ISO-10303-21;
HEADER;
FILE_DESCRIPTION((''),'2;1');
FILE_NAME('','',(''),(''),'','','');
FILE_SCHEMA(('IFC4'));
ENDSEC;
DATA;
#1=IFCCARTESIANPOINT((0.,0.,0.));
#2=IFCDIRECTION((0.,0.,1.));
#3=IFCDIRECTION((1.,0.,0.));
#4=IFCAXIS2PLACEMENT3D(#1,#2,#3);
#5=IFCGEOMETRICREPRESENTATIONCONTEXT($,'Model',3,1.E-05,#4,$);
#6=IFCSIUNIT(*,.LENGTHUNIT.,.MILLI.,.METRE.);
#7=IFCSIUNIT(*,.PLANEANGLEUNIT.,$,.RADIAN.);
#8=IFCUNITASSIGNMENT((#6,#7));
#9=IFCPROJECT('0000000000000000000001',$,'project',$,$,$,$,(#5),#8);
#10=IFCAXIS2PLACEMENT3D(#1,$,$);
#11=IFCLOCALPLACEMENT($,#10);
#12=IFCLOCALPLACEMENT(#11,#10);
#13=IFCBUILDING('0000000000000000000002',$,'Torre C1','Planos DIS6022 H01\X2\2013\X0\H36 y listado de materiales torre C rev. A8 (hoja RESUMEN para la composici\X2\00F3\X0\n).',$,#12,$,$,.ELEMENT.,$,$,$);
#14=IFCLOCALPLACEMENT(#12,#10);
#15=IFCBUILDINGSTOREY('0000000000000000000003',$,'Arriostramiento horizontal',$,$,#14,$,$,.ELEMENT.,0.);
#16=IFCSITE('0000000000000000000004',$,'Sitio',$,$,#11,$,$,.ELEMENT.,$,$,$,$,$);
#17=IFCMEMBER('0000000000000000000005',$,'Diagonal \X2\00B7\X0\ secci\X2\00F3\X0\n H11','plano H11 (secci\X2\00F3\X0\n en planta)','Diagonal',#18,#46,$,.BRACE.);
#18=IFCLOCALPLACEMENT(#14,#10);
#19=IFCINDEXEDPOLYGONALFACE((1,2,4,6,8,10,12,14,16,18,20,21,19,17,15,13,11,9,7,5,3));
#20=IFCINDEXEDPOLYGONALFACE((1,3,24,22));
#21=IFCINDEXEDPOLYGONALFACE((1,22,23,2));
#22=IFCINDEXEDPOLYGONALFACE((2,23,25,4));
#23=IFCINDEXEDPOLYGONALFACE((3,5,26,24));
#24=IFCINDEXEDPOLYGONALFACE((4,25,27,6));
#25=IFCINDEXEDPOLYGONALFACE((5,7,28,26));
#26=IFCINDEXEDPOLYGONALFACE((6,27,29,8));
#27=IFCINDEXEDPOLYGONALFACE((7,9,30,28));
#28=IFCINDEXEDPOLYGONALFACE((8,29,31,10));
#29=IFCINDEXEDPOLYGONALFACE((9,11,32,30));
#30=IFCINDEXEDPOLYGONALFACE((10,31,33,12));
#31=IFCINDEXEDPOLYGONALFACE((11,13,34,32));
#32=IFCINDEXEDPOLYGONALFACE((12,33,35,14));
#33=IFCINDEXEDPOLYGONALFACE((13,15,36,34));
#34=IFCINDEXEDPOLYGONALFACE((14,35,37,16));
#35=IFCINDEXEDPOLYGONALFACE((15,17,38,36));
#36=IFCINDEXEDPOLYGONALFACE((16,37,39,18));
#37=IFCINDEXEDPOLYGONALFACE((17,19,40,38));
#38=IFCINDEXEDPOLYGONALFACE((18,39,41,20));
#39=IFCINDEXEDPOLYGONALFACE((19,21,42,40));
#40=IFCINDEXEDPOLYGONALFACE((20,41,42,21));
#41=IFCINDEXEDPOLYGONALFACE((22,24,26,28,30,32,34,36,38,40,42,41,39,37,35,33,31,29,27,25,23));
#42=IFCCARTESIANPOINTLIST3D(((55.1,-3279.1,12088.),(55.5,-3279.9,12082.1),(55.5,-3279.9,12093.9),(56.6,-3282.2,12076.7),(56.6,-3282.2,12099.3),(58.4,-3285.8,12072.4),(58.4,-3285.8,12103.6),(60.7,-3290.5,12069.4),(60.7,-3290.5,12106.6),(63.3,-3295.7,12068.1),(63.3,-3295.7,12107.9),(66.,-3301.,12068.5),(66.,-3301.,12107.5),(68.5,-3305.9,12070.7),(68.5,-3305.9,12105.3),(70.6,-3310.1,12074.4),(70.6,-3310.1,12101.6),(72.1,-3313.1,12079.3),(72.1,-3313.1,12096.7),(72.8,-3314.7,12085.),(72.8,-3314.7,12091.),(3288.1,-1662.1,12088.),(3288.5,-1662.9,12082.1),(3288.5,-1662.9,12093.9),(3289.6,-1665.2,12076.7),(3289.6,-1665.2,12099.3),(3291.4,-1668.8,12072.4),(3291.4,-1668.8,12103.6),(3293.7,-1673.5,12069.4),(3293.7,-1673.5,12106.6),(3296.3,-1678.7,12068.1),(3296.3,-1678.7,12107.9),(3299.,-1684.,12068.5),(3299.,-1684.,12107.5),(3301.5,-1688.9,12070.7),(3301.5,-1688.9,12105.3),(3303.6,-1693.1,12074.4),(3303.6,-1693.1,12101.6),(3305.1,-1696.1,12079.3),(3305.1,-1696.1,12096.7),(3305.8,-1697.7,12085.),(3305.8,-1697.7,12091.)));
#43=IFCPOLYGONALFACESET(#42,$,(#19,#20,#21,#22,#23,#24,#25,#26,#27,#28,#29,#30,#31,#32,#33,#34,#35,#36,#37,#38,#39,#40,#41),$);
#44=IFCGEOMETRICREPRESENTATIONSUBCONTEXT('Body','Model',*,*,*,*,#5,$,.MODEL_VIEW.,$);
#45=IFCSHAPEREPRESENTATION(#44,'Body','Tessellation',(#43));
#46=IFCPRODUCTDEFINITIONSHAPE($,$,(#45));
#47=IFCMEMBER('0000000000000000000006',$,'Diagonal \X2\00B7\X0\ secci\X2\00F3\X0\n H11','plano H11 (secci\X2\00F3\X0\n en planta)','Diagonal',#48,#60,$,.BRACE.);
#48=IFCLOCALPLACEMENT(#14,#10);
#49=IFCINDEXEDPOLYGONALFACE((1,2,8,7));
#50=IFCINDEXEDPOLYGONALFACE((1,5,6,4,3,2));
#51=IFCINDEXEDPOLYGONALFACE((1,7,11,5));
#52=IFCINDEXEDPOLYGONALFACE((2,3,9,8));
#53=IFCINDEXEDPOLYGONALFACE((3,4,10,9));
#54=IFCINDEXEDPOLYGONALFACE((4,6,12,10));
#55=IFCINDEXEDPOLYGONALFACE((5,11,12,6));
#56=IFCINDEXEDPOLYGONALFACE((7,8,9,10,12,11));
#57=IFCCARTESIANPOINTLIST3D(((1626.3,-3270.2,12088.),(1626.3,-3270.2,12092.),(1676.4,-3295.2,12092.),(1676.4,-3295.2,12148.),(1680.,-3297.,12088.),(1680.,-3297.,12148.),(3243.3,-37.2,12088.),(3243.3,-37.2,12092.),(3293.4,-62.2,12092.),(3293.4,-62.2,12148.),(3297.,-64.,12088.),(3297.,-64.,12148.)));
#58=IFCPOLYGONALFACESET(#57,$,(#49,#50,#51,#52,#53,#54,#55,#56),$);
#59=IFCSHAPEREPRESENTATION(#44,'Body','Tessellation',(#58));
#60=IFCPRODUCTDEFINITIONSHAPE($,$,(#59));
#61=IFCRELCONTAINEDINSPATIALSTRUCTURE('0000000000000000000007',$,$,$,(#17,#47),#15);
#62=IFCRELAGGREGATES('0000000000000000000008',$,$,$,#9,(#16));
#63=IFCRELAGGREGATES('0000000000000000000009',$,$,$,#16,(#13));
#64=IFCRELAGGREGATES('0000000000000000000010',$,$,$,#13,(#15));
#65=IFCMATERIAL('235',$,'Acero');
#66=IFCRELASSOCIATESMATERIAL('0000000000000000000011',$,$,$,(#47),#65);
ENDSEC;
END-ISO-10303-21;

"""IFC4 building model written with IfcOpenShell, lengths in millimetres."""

from ifc_helpers import new_model, si_unit, frame, frame_2d, origin, origin_with_axes, place, context, subcontext, project, spatial, circle, l_section, extrude, material, element, save


model = new_model("IFC4")

# Units and contexts
model_context = context("Model", 3, precision=1e-05, world=origin_with_axes())
body_context = subcontext(model_context, "Body", "Model", "MODEL_VIEW")
ifc_project = project(units=[si_unit("LENGTHUNIT", "METRE", prefix="MILLI"), si_unit("PLANEANGLEUNIT", "RADIAN")], contexts=[model_context])

# Site, building, storey
site_placement = place(None, origin())
site = spatial("IfcSite", under=ifc_project, at=site_placement, Name="Sitio", CompositionType="ELEMENT")
building_placement = place(site_placement, origin())
building = spatial("IfcBuilding", under=site, at=building_placement, Name="Torre C1", Description="Planos DIS6022 H01–H36 y listado de materiales torre C rev. A8 (hoja RESUMEN para la composición).", CompositionType="ELEMENT")
storey_placement = place(building_placement, origin())
storey = spatial("IfcBuildingStorey", under=building, at=storey_placement, Name="Arriostramiento horizontal", CompositionType="ELEMENT", Elevation=0.0)

# Members
ifc_material = material(Name="235", Category="Acero")
member_1_placement = place(storey_placement, frame((64.0, -3297.0, 12088.0), z_axis=(0.894372, 0.447324, 0.0), x_axis=(-0.447324, 0.894372, 0.0)))
element("IfcMember", 1, at=member_1_placement, inside=storey, Name="Diagonal · sección H11", Description="plano H11 (sección en planta)", ObjectType="Diagonal", PredefinedType="BRACE", context=body_context, shape_type="SweptSolid", body=[
    extrude(circle(Radius=20.0), None, (0.0, 0.0, 1.0), 3614.8),
])
member_2_placement = place(storey_placement, frame((1680.0, -3297.0, 12088.0), z_axis=(0.447324, 0.894372, 0.0), x_axis=(-0.894372, 0.447324, 0.0)))
element("IfcMember", 2, at=member_2_placement, inside=storey, material=ifc_material, Name="Diagonal · sección H11", Description="plano H11 (sección en planta)", ObjectType="Diagonal", PredefinedType="BRACE", context=body_context, shape_type="SweptSolid", body=[
    extrude(l_section(Depth=60.0, Width=60.0, Thickness=4.0, at=frame_2d((30.0, 30.0))), None, (0.0, 0.0, 1.0), 3614.8),
])

save(model, "model.ifc")
